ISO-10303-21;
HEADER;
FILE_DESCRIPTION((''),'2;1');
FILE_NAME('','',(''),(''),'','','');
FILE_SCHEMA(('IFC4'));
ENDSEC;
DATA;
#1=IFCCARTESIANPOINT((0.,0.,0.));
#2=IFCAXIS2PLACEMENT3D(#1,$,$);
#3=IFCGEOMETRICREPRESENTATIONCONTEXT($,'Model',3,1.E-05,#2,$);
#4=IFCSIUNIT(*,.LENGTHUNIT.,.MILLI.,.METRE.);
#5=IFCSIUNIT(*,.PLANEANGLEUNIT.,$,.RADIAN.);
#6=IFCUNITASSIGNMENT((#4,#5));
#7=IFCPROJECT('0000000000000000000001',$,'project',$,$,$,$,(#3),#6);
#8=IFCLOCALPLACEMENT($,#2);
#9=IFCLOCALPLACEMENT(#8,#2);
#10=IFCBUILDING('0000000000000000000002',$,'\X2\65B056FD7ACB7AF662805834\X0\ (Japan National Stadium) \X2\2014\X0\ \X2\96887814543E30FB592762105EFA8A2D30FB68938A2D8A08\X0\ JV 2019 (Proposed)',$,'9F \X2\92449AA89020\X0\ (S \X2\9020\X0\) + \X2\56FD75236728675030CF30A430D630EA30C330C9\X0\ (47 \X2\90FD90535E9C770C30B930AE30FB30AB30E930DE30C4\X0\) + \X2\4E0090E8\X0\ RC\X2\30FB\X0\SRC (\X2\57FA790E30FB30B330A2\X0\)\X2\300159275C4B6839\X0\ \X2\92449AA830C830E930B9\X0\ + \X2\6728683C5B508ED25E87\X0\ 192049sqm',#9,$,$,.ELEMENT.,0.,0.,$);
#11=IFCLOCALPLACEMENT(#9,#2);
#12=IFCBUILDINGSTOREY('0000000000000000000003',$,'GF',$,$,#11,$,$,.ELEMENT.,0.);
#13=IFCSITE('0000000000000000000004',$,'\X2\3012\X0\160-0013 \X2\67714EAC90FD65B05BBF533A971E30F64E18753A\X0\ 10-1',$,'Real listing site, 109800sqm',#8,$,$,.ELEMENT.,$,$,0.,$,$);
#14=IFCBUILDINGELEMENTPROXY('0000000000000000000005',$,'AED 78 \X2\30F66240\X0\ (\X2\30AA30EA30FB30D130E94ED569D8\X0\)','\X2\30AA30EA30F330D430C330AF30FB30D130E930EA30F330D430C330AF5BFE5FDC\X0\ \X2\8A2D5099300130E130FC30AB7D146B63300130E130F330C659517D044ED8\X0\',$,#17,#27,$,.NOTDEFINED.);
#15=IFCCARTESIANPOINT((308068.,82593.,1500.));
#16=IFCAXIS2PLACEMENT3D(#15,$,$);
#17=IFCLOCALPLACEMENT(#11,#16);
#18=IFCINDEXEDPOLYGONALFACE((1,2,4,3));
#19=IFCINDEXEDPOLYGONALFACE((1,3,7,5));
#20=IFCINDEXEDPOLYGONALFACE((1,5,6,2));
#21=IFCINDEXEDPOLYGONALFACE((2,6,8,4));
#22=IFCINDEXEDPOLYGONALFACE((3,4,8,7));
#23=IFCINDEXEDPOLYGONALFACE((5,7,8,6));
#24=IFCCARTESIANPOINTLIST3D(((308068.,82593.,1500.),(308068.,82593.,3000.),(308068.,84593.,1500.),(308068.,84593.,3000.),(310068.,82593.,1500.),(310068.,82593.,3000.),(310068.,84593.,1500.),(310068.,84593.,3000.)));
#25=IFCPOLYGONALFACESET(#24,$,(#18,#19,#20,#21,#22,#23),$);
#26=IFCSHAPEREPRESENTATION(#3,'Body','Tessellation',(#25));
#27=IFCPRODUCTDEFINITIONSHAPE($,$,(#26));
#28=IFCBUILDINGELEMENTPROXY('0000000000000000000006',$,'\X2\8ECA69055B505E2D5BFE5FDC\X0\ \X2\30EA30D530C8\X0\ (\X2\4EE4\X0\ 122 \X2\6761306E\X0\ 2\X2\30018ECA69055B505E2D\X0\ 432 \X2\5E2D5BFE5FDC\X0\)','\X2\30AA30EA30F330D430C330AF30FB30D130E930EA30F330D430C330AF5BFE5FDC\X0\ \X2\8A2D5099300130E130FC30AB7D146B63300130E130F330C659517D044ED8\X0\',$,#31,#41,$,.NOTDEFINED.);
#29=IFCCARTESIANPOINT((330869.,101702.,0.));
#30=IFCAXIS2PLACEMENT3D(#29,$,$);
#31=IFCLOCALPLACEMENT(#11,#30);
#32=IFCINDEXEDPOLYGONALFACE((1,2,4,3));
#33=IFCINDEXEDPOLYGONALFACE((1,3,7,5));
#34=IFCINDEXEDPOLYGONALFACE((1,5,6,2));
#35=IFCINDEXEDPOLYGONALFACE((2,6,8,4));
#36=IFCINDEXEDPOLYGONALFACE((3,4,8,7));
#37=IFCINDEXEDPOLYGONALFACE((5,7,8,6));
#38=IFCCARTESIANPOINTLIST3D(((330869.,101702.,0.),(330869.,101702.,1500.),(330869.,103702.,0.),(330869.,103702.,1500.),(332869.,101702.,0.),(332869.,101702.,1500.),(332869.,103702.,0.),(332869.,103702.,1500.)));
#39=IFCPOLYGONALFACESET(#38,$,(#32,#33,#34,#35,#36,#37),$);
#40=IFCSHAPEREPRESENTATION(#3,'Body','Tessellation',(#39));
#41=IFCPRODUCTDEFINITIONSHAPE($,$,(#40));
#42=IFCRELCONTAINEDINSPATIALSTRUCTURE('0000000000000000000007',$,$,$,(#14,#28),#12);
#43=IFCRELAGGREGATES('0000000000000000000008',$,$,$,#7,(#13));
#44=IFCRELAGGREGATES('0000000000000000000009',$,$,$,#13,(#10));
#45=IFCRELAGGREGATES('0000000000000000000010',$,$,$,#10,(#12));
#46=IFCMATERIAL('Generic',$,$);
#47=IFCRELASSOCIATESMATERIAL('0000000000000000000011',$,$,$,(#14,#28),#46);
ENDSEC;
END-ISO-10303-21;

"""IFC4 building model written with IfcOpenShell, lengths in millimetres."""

from ifc_helpers import new_model, si_unit, frame, frame_2d, origin, place, context, project, spatial, rectangle, extrude, material, element, save


model = new_model("IFC4")

# Units and contexts
model_context = context("Model", 3, precision=1e-05, world=origin())
ifc_project = project(units=[si_unit("LENGTHUNIT", "METRE", prefix="MILLI"), si_unit("PLANEANGLEUNIT", "RADIAN")], contexts=[model_context])

# Site, building, storey
site_placement = place(None, origin())
site = spatial("IfcSite", under=ifc_project, at=site_placement, Name="〒160-0013 東京都新宿区霞ヶ丘町 10-1", ObjectType="Real listing site, 109800sqm", CompositionType="ELEMENT", RefElevation=0.0)
building_placement = place(site_placement, origin())
building = spatial("IfcBuilding", under=site, at=building_placement, Name="新国立競技場 (Japan National Stadium) — 隈研吾・大成建設・梓設計 JV 2019 (Proposed)", ObjectType="9F 鉄骨造 (S 造) + 国産木材ハイブリッド (47 都道府県スギ・カラマツ) + 一部 RC・SRC (基礎・コア)、大屋根 鉄骨トラス + 木格子軒庇 192049sqm", CompositionType="ELEMENT", ElevationOfRefHeight=0.0, ElevationOfTerrain=0.0)
storey_placement = place(building_placement, origin())
storey = spatial("IfcBuildingStorey", under=building, at=storey_placement, Name="GF", CompositionType="ELEMENT", Elevation=0.0)

# Shared definitions
ifc_material_1 = material(Name="Generic")

# Building element proxies
proxy_1_placement = place(storey_placement, frame((308068.0, 82593.0, 1500.0)))
element("IfcBuildingElementProxy", 1, at=proxy_1_placement, inside=storey, material=ifc_material_1, Name="AED 78 ヶ所 (オリ・パラ仕様)", Description="オリンピック・パラリンピック対応 設備、メーカ純正、メンテ契約付", PredefinedType="NOTDEFINED", context=model_context, shape_type="SweptSolid", body=[
    extrude(rectangle(XDim=2000.0, YDim=2000.0, at=frame_2d((1000.0, 1000.0))), frame((308068.0, 82593.0, 1500.0)), (0.0, 0.0, 1.0), 1500.0),
])
proxy_2_placement = place(storey_placement, frame((330869.0, 101702.0, 0.0)))
element("IfcBuildingElementProxy", 2, at=proxy_2_placement, inside=storey, material=ifc_material_1, Name="車椅子席対応 リフト (令 122 条の 2、車椅子席 432 席対応)", Description="オリンピック・パラリンピック対応 設備、メーカ純正、メンテ契約付", PredefinedType="NOTDEFINED", context=model_context, shape_type="SweptSolid", body=[
    extrude(rectangle(XDim=2000.0, YDim=2000.0, at=frame_2d((1000.0, 1000.0))), frame((330869.0, 101702.0, 0.0)), (0.0, 0.0, 1.0), 1500.0),
])

save(model, "model.ifc")
